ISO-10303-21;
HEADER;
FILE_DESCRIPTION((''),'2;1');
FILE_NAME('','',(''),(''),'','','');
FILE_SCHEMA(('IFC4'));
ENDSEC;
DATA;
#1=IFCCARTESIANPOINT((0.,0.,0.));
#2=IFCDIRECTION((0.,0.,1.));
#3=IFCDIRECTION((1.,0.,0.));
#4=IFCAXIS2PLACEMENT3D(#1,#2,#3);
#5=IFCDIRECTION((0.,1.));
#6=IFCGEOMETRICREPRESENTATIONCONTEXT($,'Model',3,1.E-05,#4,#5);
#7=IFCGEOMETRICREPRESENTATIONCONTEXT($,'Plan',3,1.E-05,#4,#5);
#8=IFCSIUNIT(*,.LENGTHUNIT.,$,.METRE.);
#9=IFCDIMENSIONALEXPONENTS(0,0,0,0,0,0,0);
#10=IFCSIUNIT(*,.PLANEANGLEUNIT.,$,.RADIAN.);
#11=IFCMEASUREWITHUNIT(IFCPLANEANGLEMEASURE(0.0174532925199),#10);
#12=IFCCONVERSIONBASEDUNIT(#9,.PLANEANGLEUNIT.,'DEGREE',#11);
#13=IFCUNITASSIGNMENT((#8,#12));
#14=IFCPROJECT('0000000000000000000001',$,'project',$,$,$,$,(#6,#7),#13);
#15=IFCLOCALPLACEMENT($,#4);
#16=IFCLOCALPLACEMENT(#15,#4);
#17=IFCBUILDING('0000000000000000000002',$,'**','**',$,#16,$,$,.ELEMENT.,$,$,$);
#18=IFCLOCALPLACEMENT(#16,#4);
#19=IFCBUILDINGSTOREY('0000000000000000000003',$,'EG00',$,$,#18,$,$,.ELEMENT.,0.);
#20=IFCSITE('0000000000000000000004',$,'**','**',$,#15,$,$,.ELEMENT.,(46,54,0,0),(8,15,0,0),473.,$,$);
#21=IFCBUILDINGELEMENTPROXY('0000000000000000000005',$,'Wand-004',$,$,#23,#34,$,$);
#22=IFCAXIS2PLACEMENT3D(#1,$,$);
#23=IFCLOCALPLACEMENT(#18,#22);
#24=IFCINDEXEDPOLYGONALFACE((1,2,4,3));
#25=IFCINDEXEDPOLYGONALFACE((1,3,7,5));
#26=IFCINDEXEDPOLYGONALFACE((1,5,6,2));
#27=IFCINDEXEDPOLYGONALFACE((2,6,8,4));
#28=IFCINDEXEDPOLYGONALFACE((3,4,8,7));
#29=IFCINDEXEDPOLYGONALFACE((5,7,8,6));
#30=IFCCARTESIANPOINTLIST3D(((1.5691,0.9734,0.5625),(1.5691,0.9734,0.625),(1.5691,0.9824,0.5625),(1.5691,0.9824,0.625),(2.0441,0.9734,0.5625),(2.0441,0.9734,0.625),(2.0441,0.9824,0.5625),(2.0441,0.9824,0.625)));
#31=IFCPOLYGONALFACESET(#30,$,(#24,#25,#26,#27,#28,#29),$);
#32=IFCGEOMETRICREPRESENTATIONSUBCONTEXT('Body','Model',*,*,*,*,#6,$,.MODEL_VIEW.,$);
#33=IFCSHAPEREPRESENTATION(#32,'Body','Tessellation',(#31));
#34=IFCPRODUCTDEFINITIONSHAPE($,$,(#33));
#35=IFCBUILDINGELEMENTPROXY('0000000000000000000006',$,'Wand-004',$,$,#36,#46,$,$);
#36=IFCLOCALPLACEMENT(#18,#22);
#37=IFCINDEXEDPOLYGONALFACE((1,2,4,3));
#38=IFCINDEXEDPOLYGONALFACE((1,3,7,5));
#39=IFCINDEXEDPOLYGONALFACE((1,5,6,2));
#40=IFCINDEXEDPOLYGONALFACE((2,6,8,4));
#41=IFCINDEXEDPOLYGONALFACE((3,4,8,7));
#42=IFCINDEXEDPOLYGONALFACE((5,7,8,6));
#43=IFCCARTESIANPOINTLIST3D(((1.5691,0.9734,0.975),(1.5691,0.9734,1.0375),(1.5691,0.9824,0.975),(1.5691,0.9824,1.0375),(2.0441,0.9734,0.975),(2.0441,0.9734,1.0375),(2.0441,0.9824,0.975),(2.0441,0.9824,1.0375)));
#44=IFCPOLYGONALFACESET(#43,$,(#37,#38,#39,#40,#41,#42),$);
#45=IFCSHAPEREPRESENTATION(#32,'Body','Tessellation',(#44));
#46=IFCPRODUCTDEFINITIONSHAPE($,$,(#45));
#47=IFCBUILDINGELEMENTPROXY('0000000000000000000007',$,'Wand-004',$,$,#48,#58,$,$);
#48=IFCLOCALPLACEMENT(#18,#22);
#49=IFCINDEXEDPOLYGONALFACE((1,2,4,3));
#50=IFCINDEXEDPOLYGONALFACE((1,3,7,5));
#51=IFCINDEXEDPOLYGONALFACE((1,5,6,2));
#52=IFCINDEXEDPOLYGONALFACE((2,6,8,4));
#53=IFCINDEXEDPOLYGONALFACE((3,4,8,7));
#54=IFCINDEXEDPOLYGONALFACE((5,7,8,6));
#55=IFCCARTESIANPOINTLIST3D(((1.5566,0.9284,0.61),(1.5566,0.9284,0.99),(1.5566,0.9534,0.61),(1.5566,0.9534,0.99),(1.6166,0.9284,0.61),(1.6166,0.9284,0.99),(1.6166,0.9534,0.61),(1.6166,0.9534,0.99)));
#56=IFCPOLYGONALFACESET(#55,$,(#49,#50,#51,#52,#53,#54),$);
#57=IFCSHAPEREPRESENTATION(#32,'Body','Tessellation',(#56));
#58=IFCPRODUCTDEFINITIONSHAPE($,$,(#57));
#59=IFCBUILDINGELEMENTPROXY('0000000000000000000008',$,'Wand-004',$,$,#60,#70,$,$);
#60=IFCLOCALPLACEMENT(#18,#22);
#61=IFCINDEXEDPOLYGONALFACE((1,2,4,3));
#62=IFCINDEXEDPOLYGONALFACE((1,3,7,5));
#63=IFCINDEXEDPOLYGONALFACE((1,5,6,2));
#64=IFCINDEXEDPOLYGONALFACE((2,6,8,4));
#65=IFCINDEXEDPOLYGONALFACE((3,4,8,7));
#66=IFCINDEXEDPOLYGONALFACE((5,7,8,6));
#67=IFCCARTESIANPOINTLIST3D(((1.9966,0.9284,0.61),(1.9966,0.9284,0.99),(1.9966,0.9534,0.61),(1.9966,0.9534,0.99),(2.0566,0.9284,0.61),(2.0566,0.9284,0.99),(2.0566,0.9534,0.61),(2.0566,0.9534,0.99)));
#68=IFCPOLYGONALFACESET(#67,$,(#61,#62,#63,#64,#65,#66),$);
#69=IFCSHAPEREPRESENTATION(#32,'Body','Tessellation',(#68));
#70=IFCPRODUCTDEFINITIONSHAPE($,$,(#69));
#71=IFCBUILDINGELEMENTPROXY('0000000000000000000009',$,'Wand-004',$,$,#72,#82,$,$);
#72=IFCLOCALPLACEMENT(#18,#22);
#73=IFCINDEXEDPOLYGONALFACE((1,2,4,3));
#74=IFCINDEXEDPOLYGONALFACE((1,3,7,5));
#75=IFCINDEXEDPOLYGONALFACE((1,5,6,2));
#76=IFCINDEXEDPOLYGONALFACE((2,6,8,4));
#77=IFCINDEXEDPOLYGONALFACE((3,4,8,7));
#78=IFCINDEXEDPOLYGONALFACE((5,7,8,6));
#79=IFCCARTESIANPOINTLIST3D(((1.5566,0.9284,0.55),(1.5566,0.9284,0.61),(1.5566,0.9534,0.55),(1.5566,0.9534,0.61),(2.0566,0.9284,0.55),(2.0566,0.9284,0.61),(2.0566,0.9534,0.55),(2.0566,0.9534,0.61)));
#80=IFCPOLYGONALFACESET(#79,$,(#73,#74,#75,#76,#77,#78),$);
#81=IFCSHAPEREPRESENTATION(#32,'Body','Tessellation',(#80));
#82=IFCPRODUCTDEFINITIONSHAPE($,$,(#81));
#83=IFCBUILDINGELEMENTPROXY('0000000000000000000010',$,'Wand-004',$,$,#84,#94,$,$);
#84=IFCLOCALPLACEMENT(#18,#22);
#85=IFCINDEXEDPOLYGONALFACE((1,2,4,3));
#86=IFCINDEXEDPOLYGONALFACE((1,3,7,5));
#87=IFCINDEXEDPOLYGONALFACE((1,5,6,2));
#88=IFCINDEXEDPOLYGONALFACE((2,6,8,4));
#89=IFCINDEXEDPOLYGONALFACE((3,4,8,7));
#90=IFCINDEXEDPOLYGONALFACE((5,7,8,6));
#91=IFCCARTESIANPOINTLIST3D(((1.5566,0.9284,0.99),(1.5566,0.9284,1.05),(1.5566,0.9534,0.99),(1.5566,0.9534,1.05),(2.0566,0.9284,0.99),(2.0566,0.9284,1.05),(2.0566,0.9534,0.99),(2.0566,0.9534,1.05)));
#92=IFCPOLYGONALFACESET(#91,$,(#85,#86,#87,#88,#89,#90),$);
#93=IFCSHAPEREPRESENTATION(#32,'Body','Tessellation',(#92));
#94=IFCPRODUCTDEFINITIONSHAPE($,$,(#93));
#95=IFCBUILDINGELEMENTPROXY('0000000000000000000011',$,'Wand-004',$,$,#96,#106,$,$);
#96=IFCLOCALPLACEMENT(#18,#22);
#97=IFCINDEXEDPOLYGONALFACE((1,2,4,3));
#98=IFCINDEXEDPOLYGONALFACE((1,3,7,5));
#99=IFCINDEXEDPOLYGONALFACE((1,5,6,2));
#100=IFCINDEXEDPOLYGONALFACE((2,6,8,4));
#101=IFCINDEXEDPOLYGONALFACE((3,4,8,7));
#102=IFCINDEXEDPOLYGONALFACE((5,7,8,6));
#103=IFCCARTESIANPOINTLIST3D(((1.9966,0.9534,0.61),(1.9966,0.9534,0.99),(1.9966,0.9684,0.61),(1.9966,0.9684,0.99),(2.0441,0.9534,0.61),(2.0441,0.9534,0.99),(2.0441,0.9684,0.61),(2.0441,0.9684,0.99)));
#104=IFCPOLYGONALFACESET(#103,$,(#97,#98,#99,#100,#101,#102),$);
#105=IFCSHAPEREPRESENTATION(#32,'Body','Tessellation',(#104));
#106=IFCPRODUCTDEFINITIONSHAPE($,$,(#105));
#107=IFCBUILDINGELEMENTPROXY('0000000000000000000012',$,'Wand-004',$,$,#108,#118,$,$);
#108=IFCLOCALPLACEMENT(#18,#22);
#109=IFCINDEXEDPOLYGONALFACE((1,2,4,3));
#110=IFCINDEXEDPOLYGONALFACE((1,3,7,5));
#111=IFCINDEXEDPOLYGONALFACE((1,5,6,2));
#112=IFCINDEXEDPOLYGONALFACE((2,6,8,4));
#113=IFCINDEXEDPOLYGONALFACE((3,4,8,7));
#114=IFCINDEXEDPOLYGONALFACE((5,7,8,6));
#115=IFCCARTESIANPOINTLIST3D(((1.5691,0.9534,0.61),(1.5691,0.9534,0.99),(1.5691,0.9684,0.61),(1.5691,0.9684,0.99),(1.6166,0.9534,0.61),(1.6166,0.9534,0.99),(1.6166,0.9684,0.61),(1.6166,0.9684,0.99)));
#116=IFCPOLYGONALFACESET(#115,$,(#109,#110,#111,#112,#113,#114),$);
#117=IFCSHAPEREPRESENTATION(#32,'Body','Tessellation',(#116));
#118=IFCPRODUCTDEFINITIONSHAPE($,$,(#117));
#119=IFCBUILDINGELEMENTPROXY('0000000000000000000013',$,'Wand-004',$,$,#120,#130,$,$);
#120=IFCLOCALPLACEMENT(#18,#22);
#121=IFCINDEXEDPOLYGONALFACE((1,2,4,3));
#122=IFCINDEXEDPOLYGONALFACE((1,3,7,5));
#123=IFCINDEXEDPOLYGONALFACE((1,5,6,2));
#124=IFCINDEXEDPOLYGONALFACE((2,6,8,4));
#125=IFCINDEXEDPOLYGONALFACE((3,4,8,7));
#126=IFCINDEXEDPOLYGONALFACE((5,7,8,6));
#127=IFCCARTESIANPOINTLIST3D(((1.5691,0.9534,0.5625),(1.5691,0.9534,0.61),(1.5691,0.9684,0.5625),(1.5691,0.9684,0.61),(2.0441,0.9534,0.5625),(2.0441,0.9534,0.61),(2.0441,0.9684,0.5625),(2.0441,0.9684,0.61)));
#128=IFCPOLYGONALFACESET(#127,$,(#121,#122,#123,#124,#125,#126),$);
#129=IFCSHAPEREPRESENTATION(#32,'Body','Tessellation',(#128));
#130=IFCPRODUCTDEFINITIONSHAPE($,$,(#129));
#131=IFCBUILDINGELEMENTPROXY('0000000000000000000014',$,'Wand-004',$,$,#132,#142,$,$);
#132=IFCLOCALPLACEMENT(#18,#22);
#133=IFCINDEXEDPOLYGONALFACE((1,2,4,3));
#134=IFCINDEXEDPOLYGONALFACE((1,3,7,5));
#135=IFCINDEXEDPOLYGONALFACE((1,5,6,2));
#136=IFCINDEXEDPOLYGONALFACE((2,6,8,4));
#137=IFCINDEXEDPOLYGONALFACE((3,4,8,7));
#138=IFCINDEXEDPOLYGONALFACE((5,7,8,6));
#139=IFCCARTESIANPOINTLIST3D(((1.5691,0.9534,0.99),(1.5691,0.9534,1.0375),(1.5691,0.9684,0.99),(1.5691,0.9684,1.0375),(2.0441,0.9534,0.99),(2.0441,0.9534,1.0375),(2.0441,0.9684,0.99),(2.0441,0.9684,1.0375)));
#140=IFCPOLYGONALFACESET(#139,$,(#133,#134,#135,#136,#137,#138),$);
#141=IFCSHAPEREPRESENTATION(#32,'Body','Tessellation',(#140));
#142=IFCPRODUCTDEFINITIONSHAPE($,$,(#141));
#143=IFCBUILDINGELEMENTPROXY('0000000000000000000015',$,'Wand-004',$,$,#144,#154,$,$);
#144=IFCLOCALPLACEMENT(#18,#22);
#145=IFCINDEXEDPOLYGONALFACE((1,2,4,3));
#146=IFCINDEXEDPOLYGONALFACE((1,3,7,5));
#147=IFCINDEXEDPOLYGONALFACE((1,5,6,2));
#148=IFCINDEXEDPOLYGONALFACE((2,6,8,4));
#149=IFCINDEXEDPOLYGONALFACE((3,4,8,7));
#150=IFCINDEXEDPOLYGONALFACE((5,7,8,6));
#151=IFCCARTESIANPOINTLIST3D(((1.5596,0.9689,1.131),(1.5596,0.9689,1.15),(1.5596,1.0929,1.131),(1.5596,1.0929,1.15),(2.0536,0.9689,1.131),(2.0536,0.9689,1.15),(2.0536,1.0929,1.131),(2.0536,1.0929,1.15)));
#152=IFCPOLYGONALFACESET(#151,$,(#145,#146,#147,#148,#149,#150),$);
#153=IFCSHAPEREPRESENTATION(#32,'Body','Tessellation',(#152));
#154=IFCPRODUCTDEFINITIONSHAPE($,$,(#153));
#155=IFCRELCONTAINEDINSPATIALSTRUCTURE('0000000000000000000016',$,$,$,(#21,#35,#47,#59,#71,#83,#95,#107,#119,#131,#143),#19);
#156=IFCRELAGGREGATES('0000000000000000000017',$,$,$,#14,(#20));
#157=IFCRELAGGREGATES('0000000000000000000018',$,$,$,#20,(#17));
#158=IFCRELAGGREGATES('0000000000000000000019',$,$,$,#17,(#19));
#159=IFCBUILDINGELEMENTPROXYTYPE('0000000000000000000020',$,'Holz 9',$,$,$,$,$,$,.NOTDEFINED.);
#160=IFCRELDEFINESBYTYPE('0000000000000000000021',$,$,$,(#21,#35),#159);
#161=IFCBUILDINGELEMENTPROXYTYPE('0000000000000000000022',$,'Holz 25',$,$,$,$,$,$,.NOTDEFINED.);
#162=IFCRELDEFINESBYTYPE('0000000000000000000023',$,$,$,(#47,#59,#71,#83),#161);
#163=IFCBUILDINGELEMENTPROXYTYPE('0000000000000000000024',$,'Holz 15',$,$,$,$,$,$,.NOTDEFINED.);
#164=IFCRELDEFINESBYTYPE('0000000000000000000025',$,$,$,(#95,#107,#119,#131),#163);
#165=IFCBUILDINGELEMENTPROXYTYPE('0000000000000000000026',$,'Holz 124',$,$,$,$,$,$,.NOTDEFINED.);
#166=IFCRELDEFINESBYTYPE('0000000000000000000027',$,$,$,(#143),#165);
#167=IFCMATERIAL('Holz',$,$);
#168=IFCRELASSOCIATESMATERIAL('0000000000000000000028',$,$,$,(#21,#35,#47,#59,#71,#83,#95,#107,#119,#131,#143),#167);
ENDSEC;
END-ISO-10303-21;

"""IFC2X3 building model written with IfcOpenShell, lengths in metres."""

from ifc_helpers import new_model, entity, si_unit, converted_unit, direction, frame, origin_with_axes, place, context, subcontext, project, spatial, polyline, outline, extrude, material, type_object, element, save


model = new_model("IFC2X3")

# Units and contexts
model_context = context("Model", 3, precision=1e-05, world=origin_with_axes(), true_north=direction((0.0, 1.0)))
plan_context = context("Plan", 3, precision=1e-05, world=origin_with_axes(), true_north=direction((0.0, 1.0)))
body_context = subcontext(model_context, "Body", "Model", "MODEL_VIEW")
ifc_project = project(units=[si_unit("LENGTHUNIT", "METRE"), converted_unit("PLANEANGLEUNIT", "DEGREE", entity("IfcPlaneAngleMeasure", 0.0174532925199), si_unit("PLANEANGLEUNIT", "RADIAN"), dimensions=[0, 0, 0, 0, 0, 0, 0])], contexts=[model_context, plan_context])

# Site, building, storey
site_placement = place(None, origin_with_axes())
site = spatial("IfcSite", under=ifc_project, at=site_placement, Name="**", Description="**", CompositionType="ELEMENT", RefLatitude=(46, 54, 0, 0), RefLongitude=(8, 15, 0, 0), RefElevation=473.0)
building_placement = place(site_placement, origin_with_axes())
building = spatial("IfcBuilding", under=site, at=building_placement, Name="**", Description="**", CompositionType="ELEMENT")
storey_placement = place(building_placement, origin_with_axes())
storey = spatial("IfcBuildingStorey", under=building, at=storey_placement, Name="EG00", CompositionType="ELEMENT", Elevation=0.0)

# Building element proxies
ifc_material_1 = material(Name="Holz")
building_element_proxy_type_1 = type_object("IfcBuildingElementProxyType", Name="Holz 9", PredefinedType="NOTDEFINED")
for number, where, z_axis, x_axis, name in (
    (1, (2.0441, 0.9734, 0.5625), (0.0, 0.0, 1.0), (-1.0, 0.0, 0.0), "Wand-004"),
    (2, (2.0441, 0.9734, 0.975), (0.0, 0.0, 1.0), (-1.0, 0.0, 0.0), "Wand-004"),
):
    element("IfcBuildingElementProxy", number, at=place(storey_placement, frame(where, z_axis=z_axis, x_axis=x_axis)), inside=storey, type_object=building_element_proxy_type_1, material=ifc_material_1, Name=name, context=body_context, shape_type="SweptSolid", body=[
        extrude(outline(polyline([(0.0, -0.009), (0.475, -0.009), (0.475, 0.0), (0.0, 0.0), (0.0, -0.009)])), origin_with_axes(), (0.0, 0.0, 1.0), 0.0625),
    ])
building_element_proxy_type_2 = type_object("IfcBuildingElementProxyType", Name="Holz 25", PredefinedType="NOTDEFINED")
for number, where, z_axis, x_axis, name in (
    (3, (1.5566, 0.9284, 0.61), (0.0, 0.0, 1.0), (1.0, 0.0, 0.0), "Wand-004"),
    (4, (1.9966, 0.9284, 0.61), (0.0, 0.0, 1.0), (1.0, 0.0, 0.0), "Wand-004"),
):
    element("IfcBuildingElementProxy", number, at=place(storey_placement, frame(where, z_axis=z_axis, x_axis=x_axis)), inside=storey, type_object=building_element_proxy_type_2, material=ifc_material_1, Name=name, context=body_context, shape_type="SweptSolid", body=[
        extrude(outline(polyline([(0.0, 0.0), (0.06, 0.0), (0.06, 0.025), (0.0, 0.025), (0.0, 0.0)])), origin_with_axes(), (0.0, 0.0, 1.0), 0.38),
    ])
for number, where, z_axis, x_axis, name in (
    (5, (2.0566, 0.9534, 0.55), (0.0, 0.0, 1.0), (-1.0, 0.0, 0.0), "Wand-004"),
    (6, (2.0566, 0.9534, 0.99), (0.0, 0.0, 1.0), (-1.0, 0.0, 0.0), "Wand-004"),
):
    element("IfcBuildingElementProxy", number, at=place(storey_placement, frame(where, z_axis=z_axis, x_axis=x_axis)), inside=storey, type_object=building_element_proxy_type_2, material=ifc_material_1, Name=name, context=body_context, shape_type="SweptSolid", body=[
        extrude(outline(polyline([(0.0, 0.0), (0.5, 0.0), (0.5, 0.025), (0.0, 0.025), (0.0, 0.0)])), origin_with_axes(), (0.0, 0.0, 1.0), 0.06),
    ])
building_element_proxy_type_3 = type_object("IfcBuildingElementProxyType", Name="Holz 15", PredefinedType="NOTDEFINED")
for number, where, z_axis, x_axis, name in (
    (7, (1.9966, 0.9534, 0.61), (0.0, 0.0, 1.0), (1.0, 0.0, 0.0), "Wand-004"),
    (8, (1.5691, 0.9534, 0.61), (0.0, 0.0, 1.0), (1.0, 0.0, 0.0), "Wand-004"),
):
    element("IfcBuildingElementProxy", number, at=place(storey_placement, frame(where, z_axis=z_axis, x_axis=x_axis)), inside=storey, type_object=building_element_proxy_type_3, material=ifc_material_1, Name=name, context=body_context, shape_type="SweptSolid", body=[
        extrude(outline(polyline([(0.0, 0.0), (0.0475, 0.0), (0.0475, 0.015), (0.0, 0.015), (0.0, 0.0)])), origin_with_axes(), (0.0, 0.0, 1.0), 0.38),
    ])
for number, where, z_axis, x_axis, name in (
    (9, (2.0441, 0.9684, 0.5625), (0.0, 0.0, 1.0), (-1.0, 0.0, 0.0), "Wand-004"),
    (10, (2.0441, 0.9684, 0.99), (0.0, 0.0, 1.0), (-1.0, 0.0, 0.0), "Wand-004"),
):
    element("IfcBuildingElementProxy", number, at=place(storey_placement, frame(where, z_axis=z_axis, x_axis=x_axis)), inside=storey, type_object=building_element_proxy_type_3, material=ifc_material_1, Name=name, context=body_context, shape_type="SweptSolid", body=[
        extrude(outline(polyline([(0.0, 0.0), (0.475, 0.0), (0.475, 0.015), (0.0, 0.015), (0.0, 0.0)])), origin_with_axes(), (0.0, 0.0, 1.0), 0.0475),
    ])
building_element_proxy_type_4 = type_object("IfcBuildingElementProxyType", Name="Holz 124", PredefinedType="NOTDEFINED")
proxy_1_placement = place(storey_placement, frame((1.5596, 1.0929, 1.131), z_axis=(0.0, 0.0, 1.0), x_axis=(1.0, 0.0, 0.0)))
element("IfcBuildingElementProxy", 11, at=proxy_1_placement, inside=storey, type_object=building_element_proxy_type_4, material=ifc_material_1, Name="Wand-004", context=body_context, shape_type="SweptSolid", body=[
    extrude(outline(polyline([(0.0, -0.124), (0.494, -0.124), (0.494, 0.0), (0.0, 0.0), (0.0, -0.124)])), origin_with_axes(), (0.0, 0.0, 1.0), 0.019),
])

save(model, "model.ifc")
